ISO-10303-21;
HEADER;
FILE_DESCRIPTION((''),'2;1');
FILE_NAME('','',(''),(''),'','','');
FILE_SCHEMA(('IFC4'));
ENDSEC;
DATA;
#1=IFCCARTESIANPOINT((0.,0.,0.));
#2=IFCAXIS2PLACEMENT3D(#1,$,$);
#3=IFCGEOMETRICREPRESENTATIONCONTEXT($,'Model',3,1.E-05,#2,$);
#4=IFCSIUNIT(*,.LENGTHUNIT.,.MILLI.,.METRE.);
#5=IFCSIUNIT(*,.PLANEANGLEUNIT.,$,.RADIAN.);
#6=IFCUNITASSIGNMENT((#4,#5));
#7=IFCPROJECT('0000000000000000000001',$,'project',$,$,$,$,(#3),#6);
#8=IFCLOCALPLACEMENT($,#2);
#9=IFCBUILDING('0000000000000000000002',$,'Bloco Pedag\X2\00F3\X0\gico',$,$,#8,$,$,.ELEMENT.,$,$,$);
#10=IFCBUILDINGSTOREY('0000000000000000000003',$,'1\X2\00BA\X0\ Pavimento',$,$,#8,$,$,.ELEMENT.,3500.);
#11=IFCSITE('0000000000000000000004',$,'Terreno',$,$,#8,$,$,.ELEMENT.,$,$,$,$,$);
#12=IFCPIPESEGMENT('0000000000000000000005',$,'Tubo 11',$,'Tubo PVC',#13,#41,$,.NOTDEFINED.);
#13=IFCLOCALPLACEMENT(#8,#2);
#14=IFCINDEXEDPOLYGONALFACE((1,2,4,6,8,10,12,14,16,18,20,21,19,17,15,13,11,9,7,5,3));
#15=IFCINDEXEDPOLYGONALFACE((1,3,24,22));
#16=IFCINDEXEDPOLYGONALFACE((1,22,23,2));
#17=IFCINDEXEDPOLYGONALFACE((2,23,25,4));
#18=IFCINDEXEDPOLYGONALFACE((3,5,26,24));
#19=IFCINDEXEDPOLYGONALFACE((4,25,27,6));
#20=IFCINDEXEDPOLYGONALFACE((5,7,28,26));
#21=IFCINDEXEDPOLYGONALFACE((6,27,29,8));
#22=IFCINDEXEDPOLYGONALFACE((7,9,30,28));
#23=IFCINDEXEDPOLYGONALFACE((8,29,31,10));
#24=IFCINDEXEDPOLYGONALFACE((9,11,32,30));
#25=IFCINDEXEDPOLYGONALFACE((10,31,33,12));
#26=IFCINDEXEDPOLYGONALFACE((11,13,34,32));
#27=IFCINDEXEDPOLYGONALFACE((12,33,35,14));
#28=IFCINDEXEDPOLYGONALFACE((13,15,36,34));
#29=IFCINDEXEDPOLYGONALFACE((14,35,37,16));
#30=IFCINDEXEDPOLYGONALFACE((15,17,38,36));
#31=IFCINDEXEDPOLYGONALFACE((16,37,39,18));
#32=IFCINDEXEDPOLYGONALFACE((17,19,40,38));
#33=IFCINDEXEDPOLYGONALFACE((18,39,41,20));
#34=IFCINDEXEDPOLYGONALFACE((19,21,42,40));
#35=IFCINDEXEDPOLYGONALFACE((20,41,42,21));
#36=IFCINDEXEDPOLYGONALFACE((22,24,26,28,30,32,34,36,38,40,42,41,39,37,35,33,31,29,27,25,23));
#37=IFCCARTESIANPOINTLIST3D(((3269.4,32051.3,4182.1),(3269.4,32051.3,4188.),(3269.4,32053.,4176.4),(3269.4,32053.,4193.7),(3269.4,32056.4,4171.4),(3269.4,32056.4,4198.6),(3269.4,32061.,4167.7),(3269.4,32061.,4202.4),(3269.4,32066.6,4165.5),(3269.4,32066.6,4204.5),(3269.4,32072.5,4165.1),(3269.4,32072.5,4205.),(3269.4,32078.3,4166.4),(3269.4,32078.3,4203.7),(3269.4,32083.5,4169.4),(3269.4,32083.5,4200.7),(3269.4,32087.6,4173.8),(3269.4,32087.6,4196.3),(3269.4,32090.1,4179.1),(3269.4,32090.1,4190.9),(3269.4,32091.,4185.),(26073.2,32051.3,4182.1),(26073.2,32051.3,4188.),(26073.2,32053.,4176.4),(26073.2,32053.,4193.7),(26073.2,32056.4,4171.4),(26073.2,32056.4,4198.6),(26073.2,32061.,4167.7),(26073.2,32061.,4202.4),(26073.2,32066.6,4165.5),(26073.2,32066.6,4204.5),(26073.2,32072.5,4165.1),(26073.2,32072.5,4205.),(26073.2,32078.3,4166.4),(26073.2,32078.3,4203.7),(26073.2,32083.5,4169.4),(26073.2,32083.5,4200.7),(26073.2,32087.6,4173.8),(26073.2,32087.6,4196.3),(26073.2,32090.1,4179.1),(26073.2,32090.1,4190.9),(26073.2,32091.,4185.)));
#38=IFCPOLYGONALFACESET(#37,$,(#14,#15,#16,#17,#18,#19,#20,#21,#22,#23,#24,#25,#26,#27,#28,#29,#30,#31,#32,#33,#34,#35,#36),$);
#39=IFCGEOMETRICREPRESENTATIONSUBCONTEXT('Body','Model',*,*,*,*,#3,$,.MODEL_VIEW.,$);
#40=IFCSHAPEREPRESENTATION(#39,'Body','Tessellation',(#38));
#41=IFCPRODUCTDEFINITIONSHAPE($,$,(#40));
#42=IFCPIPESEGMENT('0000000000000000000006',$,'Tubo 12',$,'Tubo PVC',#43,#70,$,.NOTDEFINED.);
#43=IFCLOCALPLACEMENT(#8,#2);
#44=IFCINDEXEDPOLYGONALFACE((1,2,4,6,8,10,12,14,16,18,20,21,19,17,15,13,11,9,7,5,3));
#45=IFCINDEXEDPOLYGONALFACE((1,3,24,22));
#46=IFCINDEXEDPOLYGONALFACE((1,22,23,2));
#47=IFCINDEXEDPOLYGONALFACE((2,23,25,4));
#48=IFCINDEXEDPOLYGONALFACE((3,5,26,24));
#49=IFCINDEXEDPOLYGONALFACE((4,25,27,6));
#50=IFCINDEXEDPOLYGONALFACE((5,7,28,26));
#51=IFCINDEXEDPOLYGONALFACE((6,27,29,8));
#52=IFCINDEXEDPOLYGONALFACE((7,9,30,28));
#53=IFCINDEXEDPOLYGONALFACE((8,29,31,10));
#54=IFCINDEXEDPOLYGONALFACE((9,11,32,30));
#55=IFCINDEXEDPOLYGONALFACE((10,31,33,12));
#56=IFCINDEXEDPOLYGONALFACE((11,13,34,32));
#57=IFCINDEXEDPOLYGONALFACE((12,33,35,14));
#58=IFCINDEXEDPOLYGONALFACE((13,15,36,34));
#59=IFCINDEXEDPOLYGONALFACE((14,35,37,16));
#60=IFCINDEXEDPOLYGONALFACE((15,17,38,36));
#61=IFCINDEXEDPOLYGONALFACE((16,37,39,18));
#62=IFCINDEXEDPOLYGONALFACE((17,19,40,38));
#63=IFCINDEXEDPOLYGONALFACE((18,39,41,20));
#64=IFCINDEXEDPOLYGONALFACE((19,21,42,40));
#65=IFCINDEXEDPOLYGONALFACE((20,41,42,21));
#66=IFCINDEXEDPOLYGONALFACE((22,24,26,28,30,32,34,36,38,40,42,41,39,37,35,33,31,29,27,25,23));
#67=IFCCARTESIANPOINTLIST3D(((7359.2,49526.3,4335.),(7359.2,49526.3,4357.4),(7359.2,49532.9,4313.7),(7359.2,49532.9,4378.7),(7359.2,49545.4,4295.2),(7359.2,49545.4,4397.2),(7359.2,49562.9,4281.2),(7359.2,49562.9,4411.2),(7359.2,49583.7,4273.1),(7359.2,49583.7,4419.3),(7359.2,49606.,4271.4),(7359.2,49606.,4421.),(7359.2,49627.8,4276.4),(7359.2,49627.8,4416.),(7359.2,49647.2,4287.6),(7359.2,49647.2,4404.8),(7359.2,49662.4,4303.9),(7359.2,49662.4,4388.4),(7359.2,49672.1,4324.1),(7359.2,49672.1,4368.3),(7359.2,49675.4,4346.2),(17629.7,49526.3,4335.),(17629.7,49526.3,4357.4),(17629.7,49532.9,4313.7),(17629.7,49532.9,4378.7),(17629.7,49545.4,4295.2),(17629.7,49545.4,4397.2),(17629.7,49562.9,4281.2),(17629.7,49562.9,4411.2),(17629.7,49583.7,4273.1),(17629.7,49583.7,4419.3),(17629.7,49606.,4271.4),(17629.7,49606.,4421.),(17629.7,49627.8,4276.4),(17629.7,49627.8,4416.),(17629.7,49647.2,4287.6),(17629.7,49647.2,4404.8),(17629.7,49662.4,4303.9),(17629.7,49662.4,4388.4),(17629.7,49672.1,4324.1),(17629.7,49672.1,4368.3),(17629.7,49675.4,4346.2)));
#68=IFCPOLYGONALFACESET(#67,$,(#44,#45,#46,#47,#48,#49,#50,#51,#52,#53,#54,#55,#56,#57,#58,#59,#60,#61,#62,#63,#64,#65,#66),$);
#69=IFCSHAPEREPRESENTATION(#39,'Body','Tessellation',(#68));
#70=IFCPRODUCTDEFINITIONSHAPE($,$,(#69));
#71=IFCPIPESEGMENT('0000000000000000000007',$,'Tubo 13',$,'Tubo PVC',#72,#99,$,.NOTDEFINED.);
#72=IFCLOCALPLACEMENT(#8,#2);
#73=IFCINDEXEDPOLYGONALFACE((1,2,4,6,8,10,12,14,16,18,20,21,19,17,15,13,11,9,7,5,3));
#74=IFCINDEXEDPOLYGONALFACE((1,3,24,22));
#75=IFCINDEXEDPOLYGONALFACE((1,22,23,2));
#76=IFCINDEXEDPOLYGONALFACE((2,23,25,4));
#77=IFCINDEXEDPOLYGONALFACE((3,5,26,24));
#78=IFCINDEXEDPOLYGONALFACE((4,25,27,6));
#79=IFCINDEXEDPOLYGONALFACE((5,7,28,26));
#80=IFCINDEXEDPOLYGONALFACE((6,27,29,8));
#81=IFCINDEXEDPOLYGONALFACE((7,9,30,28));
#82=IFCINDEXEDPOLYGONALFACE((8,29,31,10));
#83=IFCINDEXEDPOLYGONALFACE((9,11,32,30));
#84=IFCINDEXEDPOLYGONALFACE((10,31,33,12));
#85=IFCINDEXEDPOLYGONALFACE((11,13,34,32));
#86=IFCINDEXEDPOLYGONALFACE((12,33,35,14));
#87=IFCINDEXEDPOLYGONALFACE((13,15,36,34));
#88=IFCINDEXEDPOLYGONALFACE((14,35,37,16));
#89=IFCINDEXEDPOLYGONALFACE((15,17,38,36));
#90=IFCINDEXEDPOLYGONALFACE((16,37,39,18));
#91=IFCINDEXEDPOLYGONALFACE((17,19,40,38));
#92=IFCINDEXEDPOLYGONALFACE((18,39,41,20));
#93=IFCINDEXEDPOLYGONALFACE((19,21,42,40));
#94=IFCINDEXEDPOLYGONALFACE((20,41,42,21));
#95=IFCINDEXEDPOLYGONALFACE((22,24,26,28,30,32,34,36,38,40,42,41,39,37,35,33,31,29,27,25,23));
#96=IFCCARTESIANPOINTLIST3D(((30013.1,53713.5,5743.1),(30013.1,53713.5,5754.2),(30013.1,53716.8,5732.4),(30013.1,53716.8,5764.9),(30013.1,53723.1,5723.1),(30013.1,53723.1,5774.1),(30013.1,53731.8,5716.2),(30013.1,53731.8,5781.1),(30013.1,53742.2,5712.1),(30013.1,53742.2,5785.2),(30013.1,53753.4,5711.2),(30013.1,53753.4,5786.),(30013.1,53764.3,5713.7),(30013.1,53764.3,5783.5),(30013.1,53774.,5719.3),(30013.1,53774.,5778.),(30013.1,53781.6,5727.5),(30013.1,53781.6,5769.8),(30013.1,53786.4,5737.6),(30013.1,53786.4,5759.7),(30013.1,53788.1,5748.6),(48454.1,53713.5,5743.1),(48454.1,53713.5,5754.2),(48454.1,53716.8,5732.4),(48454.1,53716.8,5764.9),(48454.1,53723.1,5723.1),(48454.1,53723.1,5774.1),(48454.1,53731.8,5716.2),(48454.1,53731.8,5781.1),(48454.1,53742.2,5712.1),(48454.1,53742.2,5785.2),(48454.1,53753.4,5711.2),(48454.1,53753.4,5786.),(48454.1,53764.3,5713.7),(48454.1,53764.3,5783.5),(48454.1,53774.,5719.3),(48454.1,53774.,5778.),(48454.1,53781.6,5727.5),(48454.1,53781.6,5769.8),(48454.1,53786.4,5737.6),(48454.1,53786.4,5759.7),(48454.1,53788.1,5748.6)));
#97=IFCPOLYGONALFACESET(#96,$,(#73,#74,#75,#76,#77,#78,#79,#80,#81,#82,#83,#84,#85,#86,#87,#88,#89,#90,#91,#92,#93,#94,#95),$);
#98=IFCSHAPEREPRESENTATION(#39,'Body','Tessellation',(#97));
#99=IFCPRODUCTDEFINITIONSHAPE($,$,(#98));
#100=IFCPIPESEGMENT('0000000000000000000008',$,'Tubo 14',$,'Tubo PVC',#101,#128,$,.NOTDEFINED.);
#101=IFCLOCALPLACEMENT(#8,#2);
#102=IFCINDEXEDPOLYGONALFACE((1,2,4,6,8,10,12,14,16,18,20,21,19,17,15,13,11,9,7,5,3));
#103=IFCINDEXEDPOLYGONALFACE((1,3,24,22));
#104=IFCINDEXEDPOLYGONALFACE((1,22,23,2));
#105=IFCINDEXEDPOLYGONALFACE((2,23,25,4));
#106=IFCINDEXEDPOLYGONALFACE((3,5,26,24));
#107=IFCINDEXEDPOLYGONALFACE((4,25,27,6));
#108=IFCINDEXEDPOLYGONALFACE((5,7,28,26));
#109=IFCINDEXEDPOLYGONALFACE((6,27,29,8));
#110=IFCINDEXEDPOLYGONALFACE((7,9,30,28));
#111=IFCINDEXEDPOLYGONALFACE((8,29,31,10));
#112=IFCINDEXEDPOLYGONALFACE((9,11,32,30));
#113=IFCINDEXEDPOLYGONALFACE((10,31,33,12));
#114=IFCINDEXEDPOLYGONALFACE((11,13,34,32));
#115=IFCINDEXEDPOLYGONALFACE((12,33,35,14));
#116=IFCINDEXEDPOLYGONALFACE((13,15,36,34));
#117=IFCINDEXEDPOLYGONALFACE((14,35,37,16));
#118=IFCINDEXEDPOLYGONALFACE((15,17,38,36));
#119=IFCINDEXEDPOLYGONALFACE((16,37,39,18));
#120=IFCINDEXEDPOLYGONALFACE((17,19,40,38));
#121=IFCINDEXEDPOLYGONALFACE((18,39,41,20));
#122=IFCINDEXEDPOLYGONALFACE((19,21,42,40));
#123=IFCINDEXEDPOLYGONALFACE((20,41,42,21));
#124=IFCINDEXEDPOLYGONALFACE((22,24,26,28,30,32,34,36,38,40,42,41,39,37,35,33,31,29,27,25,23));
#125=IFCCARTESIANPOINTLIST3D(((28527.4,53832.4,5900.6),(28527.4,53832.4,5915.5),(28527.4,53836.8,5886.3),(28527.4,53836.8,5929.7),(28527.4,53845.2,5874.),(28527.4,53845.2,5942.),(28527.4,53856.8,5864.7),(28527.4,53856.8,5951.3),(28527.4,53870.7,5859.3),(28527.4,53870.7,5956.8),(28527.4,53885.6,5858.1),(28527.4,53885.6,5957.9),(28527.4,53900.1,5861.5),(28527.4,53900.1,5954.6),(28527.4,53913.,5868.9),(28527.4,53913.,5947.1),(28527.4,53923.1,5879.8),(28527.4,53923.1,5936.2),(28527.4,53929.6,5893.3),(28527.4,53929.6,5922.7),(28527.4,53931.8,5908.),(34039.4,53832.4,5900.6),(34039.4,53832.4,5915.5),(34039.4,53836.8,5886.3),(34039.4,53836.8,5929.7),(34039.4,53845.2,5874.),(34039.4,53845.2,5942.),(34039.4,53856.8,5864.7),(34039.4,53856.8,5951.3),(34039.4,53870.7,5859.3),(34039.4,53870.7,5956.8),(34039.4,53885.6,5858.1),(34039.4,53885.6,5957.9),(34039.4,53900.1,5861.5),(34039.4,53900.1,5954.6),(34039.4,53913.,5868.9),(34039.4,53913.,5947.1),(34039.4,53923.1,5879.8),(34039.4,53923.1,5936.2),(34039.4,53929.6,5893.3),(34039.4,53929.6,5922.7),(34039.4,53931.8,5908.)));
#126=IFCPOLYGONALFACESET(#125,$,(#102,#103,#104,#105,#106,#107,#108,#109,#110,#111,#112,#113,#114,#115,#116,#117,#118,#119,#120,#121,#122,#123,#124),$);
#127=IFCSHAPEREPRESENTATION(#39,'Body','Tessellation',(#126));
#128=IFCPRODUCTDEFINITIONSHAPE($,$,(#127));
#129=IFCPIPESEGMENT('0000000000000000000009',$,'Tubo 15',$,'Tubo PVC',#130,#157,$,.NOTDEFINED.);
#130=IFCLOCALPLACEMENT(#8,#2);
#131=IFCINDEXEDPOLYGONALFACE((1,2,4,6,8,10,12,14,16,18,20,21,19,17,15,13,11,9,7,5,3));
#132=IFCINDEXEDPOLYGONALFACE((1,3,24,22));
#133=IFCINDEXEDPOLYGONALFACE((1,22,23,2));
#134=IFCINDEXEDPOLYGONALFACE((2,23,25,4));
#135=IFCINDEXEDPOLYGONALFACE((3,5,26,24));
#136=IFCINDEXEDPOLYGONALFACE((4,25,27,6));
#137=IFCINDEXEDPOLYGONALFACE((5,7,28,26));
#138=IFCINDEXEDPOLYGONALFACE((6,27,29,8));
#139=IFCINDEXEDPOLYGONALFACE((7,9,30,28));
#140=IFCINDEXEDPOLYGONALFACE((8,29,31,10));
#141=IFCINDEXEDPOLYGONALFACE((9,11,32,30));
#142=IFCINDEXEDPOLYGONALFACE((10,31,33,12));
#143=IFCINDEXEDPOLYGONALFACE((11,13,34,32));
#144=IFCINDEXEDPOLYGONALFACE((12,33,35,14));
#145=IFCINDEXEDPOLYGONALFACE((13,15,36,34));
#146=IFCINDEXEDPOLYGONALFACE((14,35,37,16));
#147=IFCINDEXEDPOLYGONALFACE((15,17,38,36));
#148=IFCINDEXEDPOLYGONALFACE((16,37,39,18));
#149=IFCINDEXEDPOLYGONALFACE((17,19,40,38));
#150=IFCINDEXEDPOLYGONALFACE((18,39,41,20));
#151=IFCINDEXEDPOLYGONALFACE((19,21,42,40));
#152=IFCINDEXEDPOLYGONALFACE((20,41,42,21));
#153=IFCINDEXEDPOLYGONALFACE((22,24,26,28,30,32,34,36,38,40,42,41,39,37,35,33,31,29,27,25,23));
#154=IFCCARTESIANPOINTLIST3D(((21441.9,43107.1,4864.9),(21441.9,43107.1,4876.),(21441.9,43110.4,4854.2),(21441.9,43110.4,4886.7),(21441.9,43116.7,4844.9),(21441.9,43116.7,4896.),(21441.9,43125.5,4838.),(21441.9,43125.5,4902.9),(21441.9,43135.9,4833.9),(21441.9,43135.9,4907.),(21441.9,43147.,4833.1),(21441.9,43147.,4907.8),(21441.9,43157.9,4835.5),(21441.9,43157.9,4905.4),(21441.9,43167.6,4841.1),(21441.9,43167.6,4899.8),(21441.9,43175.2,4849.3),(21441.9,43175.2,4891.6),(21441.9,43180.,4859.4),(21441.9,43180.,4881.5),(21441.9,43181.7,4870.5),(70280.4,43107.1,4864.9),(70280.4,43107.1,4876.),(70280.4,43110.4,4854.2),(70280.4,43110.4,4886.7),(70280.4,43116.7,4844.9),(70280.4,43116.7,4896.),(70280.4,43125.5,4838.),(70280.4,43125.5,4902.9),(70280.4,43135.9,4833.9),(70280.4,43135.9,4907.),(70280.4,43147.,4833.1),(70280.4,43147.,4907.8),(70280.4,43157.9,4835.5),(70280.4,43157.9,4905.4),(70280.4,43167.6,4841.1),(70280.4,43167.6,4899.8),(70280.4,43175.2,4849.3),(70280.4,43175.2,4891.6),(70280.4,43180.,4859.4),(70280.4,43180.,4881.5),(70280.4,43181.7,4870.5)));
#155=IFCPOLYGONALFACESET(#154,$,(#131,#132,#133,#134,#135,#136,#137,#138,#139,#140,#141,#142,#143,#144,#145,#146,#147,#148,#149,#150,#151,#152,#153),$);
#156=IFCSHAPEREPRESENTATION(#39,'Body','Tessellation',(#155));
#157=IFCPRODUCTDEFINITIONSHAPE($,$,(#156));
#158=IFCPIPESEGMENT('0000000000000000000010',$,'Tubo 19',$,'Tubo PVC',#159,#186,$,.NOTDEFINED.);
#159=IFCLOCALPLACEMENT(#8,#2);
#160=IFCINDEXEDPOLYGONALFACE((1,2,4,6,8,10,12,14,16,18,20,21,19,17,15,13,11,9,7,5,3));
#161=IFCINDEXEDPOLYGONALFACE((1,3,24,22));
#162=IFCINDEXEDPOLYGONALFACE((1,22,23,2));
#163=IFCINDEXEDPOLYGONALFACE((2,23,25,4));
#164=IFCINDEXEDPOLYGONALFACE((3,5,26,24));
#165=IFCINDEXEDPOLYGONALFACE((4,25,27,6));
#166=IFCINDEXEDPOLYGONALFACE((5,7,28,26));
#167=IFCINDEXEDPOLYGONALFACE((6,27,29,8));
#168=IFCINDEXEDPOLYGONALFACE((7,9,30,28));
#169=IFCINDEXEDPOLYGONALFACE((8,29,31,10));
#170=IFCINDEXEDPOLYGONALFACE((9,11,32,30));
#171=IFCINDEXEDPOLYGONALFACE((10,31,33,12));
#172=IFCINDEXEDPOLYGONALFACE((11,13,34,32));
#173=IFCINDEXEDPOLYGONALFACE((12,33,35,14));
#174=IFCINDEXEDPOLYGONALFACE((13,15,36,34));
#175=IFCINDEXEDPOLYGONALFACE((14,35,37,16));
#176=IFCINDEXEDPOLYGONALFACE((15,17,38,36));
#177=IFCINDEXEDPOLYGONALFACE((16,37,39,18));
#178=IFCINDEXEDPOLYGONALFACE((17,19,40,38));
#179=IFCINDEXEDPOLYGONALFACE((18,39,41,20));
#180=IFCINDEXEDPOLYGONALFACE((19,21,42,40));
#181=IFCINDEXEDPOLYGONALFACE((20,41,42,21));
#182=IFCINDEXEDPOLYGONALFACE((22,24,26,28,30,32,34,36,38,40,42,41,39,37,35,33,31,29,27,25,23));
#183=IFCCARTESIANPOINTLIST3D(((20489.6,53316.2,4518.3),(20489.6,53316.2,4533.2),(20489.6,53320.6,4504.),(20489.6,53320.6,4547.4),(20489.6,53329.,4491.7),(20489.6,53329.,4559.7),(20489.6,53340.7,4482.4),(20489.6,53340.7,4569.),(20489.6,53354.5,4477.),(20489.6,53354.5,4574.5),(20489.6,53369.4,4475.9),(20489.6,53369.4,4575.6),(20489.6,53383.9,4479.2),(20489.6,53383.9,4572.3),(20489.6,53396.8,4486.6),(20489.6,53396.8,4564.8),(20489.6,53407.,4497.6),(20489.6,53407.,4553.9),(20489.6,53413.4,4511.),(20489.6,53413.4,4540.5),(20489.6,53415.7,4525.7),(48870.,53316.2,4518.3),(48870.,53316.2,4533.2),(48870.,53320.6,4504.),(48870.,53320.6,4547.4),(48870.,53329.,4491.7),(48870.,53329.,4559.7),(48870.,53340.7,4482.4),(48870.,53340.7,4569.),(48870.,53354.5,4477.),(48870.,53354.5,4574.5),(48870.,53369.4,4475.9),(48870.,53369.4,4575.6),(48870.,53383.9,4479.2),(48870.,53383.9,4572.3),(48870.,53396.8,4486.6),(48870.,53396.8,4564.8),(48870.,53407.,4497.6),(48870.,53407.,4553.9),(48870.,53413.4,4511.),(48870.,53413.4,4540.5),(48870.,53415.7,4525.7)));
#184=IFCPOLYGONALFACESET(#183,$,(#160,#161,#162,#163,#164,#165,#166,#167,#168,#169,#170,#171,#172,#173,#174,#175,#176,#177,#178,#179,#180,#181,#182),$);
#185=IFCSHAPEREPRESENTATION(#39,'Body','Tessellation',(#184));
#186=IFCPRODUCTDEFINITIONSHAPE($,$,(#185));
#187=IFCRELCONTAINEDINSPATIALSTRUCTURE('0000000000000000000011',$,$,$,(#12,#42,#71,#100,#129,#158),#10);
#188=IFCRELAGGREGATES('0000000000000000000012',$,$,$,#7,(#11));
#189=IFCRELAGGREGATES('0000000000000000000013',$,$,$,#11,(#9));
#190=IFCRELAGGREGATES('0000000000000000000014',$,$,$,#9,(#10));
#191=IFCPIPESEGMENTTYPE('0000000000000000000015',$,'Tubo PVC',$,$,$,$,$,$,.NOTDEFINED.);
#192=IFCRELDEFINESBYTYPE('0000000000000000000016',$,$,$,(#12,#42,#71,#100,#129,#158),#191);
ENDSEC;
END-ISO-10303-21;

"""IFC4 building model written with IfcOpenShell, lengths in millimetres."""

from ifc_helpers import new_model, si_unit, frame, origin, origin_2d, place, context, subcontext, project, spatial, circle, extrude, type_object, element, save


model = new_model("IFC4")

# Units and contexts
model_context = context("Model", 3, precision=1e-05, world=origin())
body_context = subcontext(model_context, "Body", "Model", "MODEL_VIEW")
ifc_project = project(units=[si_unit("LENGTHUNIT", "METRE", prefix="MILLI"), si_unit("PLANEANGLEUNIT", "RADIAN")], contexts=[model_context])

# Site, building, storey
placement = place(None, origin())
site = spatial("IfcSite", under=ifc_project, at=placement, Name="Terreno", CompositionType="ELEMENT")
building = spatial("IfcBuilding", under=site, at=placement, Name="Bloco Pedagógico", CompositionType="ELEMENT")
storey = spatial("IfcBuildingStorey", under=building, at=placement, Name="1º Pavimento", CompositionType="ELEMENT", Elevation=3500.0)

# Pipe segments
pipe_segment_type = type_object("IfcPipeSegmentType", Name="Tubo PVC", PredefinedType="NOTDEFINED")
pipe_segment_1_placement = place(None, frame((3269.4, 32071.0, 4185.0), z_axis=(1.0, 0.0, 0.0), x_axis=(0.0, 1.0, 0.0)))
element("IfcPipeSegment", 1, at=pipe_segment_1_placement, inside=storey, type_object=pipe_segment_type, Name="Tubo 11", ObjectType="Tubo PVC", PredefinedType="NOTDEFINED", context=body_context, shape_type="SweptSolid", body=[
    extrude(circle(Radius=20.0, at=origin_2d()), None, (0.0, 0.0, 1.0), 22803.8),
])
pipe_segment_2_placement = place(None, frame((7359.2, 49600.4, 4346.2), z_axis=(1.0, 0.0, 0.0), x_axis=(0.0, 1.0, 0.0)))
element("IfcPipeSegment", 2, at=pipe_segment_2_placement, inside=storey, type_object=pipe_segment_type, Name="Tubo 12", ObjectType="Tubo PVC", PredefinedType="NOTDEFINED", context=body_context, shape_type="SweptSolid", body=[
    extrude(circle(Radius=75.0, at=origin_2d()), None, (0.0, 0.0, 1.0), 10270.4),
])
pipe_segment_3_placement = place(None, frame((30013.1, 53750.6, 5748.6), z_axis=(1.0, 0.0, 0.0), x_axis=(0.0, 1.0, 0.0)))
element("IfcPipeSegment", 3, at=pipe_segment_3_placement, inside=storey, type_object=pipe_segment_type, Name="Tubo 13", ObjectType="Tubo PVC", PredefinedType="NOTDEFINED", context=body_context, shape_type="SweptSolid", body=[
    extrude(circle(Radius=37.5, at=origin_2d()), None, (0.0, 0.0, 1.0), 18441.0),
])
pipe_segment_4_placement = place(None, frame((28527.4, 53881.8, 5908.0), z_axis=(1.0, 0.0, 0.0), x_axis=(0.0, 1.0, 0.0)))
element("IfcPipeSegment", 4, at=pipe_segment_4_placement, inside=storey, type_object=pipe_segment_type, Name="Tubo 14", ObjectType="Tubo PVC", PredefinedType="NOTDEFINED", context=body_context, shape_type="SweptSolid", body=[
    extrude(circle(Radius=50.0, at=origin_2d()), None, (0.0, 0.0, 1.0), 5512.0),
])
pipe_segment_5_placement = place(None, frame((21441.9, 43144.2, 4870.5), z_axis=(1.0, 0.0, 0.0), x_axis=(0.0, 1.0, 0.0)))
element("IfcPipeSegment", 5, at=pipe_segment_5_placement, inside=storey, type_object=pipe_segment_type, Name="Tubo 15", ObjectType="Tubo PVC", PredefinedType="NOTDEFINED", context=body_context, shape_type="SweptSolid", body=[
    extrude(circle(Radius=37.5, at=origin_2d()), None, (0.0, 0.0, 1.0), 48838.5),
])
pipe_segment_6_placement = place(None, frame((20489.6, 53365.7, 4525.7), z_axis=(1.0, 0.0, 0.0), x_axis=(0.0, 1.0, 0.0)))
element("IfcPipeSegment", 6, at=pipe_segment_6_placement, inside=storey, type_object=pipe_segment_type, Name="Tubo 19", ObjectType="Tubo PVC", PredefinedType="NOTDEFINED", context=body_context, shape_type="SweptSolid", body=[
    extrude(circle(Radius=50.0, at=origin_2d()), None, (0.0, 0.0, 1.0), 28380.4),
])

save(model, "model.ifc")
